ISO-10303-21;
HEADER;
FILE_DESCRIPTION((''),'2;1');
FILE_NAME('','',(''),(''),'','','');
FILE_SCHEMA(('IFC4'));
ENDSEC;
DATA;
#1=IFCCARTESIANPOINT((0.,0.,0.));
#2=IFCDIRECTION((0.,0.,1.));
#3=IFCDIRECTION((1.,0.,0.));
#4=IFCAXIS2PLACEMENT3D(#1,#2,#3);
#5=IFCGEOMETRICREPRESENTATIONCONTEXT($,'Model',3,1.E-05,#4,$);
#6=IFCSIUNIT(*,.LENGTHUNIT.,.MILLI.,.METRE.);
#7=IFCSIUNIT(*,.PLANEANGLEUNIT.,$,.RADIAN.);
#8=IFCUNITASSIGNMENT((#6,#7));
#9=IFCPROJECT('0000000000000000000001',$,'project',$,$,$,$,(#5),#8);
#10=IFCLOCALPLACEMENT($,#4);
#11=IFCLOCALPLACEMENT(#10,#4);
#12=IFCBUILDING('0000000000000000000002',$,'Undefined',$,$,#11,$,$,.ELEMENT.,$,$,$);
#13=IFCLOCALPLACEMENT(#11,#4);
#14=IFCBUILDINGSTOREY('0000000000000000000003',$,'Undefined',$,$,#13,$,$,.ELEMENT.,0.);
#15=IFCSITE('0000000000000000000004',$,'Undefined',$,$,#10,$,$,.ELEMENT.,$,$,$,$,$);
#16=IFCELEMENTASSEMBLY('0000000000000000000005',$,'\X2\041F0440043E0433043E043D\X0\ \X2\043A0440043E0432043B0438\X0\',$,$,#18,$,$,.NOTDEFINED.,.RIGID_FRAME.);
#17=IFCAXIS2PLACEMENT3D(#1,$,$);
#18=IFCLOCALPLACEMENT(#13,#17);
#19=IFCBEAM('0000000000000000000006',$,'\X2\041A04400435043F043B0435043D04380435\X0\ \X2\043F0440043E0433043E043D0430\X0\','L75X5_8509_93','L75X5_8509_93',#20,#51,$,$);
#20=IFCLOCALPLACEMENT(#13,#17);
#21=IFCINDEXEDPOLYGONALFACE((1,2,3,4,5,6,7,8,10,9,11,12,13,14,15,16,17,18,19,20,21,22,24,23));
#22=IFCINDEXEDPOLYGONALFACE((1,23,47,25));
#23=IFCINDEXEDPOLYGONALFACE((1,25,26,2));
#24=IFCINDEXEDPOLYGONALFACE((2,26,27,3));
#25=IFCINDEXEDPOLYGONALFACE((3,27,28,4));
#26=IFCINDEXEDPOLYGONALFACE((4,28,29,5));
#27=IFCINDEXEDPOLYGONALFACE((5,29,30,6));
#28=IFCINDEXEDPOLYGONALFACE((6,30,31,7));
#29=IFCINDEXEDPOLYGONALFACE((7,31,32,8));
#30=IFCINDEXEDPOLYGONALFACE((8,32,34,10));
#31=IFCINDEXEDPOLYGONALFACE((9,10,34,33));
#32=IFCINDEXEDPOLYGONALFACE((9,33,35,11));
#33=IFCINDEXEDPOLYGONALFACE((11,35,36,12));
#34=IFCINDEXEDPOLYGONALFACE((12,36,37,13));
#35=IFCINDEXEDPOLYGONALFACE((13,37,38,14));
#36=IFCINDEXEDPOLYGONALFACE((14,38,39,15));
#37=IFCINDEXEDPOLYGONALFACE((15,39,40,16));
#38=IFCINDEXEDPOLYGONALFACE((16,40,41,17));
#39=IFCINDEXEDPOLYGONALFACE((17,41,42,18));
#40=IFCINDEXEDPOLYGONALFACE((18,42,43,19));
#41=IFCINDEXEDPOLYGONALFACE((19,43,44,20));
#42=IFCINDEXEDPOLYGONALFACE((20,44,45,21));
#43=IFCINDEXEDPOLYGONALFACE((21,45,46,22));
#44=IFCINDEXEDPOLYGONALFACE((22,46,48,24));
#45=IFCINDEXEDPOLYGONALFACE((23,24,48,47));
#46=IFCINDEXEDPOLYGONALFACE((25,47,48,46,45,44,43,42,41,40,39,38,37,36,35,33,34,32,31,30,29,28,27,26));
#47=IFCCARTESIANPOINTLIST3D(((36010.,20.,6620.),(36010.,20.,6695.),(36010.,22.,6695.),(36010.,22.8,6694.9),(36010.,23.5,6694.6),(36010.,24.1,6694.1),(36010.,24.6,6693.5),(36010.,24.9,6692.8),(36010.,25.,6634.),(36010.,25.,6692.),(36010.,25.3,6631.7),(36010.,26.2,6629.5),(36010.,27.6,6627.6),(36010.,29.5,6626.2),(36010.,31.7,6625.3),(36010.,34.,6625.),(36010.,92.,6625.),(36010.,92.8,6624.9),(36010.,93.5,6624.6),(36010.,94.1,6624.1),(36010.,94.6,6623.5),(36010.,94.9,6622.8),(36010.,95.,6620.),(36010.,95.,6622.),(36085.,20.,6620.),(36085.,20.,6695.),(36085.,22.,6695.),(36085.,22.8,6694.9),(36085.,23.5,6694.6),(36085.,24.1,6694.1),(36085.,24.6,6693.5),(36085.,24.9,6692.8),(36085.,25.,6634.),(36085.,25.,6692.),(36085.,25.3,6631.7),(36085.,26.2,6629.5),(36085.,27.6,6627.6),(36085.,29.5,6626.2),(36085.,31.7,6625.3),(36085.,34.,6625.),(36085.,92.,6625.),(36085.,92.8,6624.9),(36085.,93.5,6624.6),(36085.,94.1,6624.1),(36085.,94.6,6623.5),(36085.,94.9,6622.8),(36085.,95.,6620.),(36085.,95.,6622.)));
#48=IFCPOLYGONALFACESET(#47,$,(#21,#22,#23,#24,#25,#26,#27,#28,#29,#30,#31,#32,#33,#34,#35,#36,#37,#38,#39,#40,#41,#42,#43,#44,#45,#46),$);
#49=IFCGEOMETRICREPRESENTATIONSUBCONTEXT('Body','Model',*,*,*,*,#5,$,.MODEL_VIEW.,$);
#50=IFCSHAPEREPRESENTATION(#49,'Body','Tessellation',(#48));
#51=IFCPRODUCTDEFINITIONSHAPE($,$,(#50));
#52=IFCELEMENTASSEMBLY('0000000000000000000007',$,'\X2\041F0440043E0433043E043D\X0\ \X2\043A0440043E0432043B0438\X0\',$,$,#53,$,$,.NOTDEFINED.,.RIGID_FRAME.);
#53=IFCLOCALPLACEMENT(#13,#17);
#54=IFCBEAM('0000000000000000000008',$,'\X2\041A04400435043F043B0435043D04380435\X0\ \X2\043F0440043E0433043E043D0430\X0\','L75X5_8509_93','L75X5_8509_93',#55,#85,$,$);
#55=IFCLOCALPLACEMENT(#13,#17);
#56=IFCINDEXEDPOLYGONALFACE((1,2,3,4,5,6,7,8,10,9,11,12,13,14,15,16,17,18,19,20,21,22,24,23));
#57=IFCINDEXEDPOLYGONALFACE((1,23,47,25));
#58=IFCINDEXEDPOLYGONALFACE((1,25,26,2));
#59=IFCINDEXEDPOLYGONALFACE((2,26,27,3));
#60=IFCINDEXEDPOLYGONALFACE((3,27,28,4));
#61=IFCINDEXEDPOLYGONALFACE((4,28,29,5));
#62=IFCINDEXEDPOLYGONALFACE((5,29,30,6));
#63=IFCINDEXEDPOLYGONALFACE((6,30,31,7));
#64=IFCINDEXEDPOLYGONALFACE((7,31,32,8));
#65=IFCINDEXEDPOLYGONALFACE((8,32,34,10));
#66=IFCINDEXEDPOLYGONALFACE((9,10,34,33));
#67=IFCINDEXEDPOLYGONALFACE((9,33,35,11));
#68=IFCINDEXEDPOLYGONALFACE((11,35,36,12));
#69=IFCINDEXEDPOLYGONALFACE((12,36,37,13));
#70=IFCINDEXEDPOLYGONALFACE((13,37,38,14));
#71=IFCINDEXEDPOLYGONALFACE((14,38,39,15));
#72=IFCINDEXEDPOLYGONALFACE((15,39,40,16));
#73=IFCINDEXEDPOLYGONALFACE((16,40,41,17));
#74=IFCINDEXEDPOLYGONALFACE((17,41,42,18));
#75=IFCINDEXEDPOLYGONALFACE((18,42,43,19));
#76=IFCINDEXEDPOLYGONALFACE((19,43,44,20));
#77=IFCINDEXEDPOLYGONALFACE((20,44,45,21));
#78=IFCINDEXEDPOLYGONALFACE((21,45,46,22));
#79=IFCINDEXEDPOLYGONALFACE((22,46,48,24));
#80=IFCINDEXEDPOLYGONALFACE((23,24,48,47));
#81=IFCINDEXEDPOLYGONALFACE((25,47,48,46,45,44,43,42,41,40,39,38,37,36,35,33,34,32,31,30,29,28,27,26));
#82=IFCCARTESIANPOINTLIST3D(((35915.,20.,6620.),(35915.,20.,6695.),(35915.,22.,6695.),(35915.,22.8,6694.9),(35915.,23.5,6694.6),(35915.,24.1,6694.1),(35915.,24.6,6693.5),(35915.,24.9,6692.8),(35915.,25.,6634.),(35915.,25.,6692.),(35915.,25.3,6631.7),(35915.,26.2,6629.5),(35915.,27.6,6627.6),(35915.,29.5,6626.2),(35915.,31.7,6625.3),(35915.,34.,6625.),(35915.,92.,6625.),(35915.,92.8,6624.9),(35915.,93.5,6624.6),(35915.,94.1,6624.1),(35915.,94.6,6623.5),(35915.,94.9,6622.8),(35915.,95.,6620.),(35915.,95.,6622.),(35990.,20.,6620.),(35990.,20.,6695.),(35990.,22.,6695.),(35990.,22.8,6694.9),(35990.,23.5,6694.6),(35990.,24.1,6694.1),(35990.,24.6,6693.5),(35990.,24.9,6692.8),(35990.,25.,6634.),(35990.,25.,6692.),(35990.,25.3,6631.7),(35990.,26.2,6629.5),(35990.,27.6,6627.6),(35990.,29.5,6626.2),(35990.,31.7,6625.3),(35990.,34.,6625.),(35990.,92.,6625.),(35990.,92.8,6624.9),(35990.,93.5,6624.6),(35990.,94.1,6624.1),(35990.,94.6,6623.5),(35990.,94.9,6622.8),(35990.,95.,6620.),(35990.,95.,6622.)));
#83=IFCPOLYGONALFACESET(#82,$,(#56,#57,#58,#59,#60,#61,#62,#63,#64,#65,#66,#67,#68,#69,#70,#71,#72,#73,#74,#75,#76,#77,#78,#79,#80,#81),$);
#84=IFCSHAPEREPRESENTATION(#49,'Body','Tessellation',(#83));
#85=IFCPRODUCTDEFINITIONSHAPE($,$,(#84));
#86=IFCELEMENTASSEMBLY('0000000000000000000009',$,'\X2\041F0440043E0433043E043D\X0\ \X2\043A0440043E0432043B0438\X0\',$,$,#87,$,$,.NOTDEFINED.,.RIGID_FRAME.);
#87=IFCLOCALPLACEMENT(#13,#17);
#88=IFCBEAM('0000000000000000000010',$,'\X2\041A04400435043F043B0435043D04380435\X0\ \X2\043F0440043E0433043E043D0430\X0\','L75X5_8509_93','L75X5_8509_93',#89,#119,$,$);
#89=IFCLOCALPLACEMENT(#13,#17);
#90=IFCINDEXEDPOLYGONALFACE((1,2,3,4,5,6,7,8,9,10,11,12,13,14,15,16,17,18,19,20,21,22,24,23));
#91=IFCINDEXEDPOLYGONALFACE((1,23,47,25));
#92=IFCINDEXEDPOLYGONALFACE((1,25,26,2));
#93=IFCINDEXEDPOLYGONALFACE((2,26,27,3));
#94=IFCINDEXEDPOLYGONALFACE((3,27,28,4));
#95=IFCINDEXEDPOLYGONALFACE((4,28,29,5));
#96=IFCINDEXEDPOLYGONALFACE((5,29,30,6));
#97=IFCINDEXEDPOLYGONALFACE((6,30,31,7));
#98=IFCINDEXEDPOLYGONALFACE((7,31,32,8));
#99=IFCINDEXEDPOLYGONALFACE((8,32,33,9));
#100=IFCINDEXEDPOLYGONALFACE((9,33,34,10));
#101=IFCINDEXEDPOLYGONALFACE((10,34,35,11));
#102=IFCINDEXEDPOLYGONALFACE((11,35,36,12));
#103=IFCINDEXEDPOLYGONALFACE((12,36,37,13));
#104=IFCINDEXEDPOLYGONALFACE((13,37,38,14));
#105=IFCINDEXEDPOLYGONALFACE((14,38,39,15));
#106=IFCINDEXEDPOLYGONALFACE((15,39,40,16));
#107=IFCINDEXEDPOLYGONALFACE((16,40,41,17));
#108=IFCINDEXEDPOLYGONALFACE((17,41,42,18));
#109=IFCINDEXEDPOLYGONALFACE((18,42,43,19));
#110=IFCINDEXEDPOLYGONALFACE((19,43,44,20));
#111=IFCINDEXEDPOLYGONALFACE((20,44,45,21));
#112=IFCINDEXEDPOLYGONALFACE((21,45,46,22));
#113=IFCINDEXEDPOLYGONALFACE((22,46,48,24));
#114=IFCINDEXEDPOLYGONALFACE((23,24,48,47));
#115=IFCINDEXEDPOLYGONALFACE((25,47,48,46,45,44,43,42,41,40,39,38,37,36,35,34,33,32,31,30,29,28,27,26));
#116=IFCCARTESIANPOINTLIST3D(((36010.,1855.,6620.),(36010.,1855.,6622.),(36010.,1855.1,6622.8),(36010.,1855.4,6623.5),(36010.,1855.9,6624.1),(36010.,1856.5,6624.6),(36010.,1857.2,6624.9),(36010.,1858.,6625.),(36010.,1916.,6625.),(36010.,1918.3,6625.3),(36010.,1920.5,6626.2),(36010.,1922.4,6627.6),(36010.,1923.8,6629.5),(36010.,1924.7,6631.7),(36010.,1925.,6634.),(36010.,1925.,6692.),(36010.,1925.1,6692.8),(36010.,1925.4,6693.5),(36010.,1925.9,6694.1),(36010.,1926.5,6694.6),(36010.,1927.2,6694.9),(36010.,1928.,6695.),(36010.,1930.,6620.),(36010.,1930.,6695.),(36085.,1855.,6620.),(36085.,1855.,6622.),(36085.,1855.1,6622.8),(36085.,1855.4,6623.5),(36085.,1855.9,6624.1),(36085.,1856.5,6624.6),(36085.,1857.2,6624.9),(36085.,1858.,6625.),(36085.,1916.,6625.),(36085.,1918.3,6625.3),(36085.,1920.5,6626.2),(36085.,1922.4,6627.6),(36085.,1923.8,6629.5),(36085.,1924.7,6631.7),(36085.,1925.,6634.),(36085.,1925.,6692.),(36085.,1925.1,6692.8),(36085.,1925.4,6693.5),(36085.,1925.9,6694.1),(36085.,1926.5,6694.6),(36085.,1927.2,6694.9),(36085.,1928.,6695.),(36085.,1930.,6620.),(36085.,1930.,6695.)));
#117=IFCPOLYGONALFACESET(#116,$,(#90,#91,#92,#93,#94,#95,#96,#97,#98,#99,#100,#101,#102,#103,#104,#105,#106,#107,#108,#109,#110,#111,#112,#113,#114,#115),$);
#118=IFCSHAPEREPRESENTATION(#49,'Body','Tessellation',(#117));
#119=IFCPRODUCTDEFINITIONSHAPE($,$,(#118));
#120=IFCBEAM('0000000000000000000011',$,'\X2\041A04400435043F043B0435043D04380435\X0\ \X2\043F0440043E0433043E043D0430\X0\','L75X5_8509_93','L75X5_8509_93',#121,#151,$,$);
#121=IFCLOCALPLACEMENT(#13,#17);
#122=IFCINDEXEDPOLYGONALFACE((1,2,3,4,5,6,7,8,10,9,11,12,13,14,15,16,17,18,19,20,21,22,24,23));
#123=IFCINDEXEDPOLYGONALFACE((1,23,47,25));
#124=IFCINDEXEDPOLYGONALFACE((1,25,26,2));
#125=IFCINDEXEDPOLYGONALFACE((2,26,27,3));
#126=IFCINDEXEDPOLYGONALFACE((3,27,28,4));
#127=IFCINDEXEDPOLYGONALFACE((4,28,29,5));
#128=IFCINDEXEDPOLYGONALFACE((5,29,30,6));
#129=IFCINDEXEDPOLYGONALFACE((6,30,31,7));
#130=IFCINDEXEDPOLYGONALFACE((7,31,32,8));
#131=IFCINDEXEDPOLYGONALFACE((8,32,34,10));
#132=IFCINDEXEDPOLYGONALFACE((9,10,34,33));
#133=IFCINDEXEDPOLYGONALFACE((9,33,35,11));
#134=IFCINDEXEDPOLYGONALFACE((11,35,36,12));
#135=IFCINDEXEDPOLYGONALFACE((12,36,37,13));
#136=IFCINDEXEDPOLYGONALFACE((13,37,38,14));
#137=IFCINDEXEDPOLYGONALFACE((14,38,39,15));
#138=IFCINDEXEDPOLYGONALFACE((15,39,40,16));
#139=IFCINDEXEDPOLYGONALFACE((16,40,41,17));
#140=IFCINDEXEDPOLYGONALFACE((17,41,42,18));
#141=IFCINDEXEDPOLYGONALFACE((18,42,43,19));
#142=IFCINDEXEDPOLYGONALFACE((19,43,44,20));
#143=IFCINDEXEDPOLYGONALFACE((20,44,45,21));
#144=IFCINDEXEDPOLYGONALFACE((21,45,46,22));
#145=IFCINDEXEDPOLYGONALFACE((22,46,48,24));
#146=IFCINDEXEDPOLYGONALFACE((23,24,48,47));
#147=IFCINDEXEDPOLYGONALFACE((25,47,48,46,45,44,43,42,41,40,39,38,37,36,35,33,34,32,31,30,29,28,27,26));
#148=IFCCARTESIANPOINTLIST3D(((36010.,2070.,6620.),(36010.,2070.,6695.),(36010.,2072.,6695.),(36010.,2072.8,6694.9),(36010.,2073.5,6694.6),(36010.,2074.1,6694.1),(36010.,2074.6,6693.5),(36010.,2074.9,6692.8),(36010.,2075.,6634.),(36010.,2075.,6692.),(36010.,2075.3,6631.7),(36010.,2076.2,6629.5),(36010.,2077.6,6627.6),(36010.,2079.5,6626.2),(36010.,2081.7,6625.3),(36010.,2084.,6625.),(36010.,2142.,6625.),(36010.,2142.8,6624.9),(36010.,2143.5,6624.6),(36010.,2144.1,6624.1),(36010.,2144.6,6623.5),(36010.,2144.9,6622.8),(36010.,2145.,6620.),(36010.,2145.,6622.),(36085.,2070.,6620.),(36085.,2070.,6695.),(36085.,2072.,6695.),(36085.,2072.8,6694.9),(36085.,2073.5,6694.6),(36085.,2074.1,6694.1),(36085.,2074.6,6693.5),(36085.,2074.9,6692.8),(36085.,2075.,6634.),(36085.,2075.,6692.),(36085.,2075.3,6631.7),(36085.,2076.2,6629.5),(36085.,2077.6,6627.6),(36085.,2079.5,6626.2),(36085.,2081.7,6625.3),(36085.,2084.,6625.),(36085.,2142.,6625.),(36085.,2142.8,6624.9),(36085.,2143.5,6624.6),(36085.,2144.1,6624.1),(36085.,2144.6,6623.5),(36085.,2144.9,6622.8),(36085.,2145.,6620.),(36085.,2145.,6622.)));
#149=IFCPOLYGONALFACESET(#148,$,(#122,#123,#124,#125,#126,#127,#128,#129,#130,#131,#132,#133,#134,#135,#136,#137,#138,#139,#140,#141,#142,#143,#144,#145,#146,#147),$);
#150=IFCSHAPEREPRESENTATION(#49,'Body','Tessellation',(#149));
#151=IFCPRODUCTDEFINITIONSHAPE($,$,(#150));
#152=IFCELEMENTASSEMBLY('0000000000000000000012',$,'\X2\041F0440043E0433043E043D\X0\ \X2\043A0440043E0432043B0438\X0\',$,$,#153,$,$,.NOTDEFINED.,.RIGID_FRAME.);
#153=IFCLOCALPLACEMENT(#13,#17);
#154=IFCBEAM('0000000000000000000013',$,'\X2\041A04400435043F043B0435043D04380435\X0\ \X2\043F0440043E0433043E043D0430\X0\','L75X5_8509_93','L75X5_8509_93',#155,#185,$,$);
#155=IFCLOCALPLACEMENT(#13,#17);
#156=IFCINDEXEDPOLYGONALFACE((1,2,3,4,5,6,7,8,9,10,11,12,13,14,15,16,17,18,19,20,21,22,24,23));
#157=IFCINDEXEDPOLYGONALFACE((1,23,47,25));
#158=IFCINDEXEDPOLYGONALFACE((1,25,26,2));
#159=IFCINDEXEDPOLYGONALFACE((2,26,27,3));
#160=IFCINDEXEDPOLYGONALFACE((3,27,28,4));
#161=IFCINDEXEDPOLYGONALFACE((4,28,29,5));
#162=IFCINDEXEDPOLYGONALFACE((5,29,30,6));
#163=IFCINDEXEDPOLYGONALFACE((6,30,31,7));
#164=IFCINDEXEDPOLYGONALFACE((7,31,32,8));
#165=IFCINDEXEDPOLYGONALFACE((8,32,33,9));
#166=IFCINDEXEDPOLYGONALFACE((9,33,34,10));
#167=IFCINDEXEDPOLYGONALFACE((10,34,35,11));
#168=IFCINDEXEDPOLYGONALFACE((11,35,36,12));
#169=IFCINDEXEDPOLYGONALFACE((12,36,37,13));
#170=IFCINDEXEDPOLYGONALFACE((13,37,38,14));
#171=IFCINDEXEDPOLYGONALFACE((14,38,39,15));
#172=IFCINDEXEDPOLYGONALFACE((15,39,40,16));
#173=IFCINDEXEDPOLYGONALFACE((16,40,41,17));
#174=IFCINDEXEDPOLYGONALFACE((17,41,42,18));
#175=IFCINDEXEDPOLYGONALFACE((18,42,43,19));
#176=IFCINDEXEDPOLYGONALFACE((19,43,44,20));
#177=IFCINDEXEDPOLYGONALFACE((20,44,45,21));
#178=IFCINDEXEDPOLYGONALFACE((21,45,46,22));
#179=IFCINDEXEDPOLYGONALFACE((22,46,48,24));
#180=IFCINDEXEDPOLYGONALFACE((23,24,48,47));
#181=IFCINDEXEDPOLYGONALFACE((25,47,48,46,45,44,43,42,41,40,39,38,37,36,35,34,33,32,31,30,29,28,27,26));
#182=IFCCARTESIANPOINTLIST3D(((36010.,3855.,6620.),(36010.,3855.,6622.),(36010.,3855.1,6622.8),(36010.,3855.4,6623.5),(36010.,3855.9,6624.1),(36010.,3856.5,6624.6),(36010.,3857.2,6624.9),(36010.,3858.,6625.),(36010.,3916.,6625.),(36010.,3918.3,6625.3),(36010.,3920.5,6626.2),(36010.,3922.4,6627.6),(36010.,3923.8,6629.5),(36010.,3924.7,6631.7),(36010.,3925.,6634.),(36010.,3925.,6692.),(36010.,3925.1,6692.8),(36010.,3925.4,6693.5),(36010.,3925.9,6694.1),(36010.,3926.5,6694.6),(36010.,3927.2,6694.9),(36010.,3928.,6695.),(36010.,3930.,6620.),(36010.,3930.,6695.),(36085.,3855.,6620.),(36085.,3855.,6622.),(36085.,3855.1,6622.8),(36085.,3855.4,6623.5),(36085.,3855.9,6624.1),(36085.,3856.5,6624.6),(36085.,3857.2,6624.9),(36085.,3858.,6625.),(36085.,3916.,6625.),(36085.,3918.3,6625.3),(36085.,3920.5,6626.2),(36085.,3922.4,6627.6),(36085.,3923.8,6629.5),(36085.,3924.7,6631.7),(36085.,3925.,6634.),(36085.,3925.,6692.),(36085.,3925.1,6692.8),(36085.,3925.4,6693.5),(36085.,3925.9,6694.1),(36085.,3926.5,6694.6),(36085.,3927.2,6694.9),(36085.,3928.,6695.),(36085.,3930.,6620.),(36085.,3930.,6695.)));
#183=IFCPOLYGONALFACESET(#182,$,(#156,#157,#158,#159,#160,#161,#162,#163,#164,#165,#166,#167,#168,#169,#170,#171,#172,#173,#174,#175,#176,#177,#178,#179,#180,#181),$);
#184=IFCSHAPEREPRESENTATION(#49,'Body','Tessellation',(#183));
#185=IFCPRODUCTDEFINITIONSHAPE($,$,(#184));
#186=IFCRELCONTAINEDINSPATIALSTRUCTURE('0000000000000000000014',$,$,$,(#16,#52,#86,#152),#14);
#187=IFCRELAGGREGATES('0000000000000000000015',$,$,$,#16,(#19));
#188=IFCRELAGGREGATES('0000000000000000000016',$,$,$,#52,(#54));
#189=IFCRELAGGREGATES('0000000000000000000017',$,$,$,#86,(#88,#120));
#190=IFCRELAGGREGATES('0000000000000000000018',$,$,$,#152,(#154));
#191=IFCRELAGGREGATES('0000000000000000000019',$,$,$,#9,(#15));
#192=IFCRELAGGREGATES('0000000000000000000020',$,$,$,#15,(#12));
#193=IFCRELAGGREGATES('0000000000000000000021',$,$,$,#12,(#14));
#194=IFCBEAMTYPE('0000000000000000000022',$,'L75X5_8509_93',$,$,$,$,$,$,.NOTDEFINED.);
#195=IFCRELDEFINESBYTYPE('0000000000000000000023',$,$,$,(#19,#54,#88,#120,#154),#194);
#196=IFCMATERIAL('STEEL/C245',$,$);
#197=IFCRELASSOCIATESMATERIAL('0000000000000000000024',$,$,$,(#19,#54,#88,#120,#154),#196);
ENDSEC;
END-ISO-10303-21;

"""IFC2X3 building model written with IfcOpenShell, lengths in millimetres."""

from ifc_helpers import new_model, si_unit, frame, origin_with_axes, origin_2d_with_axis, place, context, subcontext, project, spatial, l_section, extrude, material, type_object, element, aggregate, save


model = new_model("IFC2X3")

# Units and contexts
model_context = context("Model", 3, precision=1e-05, world=origin_with_axes())
body_context = subcontext(model_context, "Body", "Model", "MODEL_VIEW")
ifc_project = project(units=[si_unit("LENGTHUNIT", "METRE", prefix="MILLI"), si_unit("PLANEANGLEUNIT", "RADIAN")], contexts=[model_context])

# Site, building, storey
site_placement = place(None, origin_with_axes())
site = spatial("IfcSite", under=ifc_project, at=site_placement, Name="Undefined", CompositionType="ELEMENT")
building_placement = place(site_placement, origin_with_axes())
building = spatial("IfcBuilding", under=site, at=building_placement, Name="Undefined", CompositionType="ELEMENT")
storey_placement = place(building_placement, origin_with_axes())
storey = spatial("IfcBuildingStorey", under=building, at=storey_placement, Name="Undefined", CompositionType="ELEMENT", Elevation=0.0)

# Element assemblies, beams
assembly_1_placement = place(storey_placement, origin_with_axes())
assembly_1 = element("IfcElementAssembly", 1, at=assembly_1_placement, inside=storey, Name="Прогон кровли", AssemblyPlace="NOTDEFINED", PredefinedType="RIGID_FRAME")
ifc_material_1 = material(Name="STEEL/C245")
beam_type_1 = type_object("IfcBeamType", Name="L75X5_8509_93", PredefinedType="NOTDEFINED")
beam_1_placement = place(assembly_1_placement, frame((36010.0, 57.5, 6657.5), z_axis=(0.0, 1.0, 0.0), x_axis=(1.0, 0.0, 0.0)))
beam_1 = element("IfcBeam", 2, at=beam_1_placement, type_object=beam_type_1, material=ifc_material_1, Name="Крепление прогона", Description="L75X5_8509_93", ObjectType="L75X5_8509_93", context=body_context, shape_type="SweptSolid", body=[
    extrude(l_section(Depth=75.0, Width=75.0, Thickness=5.0, FilletRadius=9.0, EdgeRadius=3.0, at=origin_2d_with_axis()), frame((75.0, 0.0, 0.0), z_axis=(-1.0, 0.0, 0.0), x_axis=(0.0, -1.0, 0.0)), (0.0, 0.0, 1.0), 75.0),
])
assembly_2_placement = place(storey_placement, origin_with_axes())
assembly_2 = element("IfcElementAssembly", 3, at=assembly_2_placement, inside=storey, Name="Прогон кровли", AssemblyPlace="NOTDEFINED", PredefinedType="RIGID_FRAME")
beam_2_placement = place(assembly_2_placement, frame((35915.0, 57.5, 6657.5), z_axis=(0.0, 1.0, 0.0), x_axis=(1.0, 0.0, 0.0)))
beam_2 = element("IfcBeam", 4, at=beam_2_placement, type_object=beam_type_1, material=ifc_material_1, Name="Крепление прогона", Description="L75X5_8509_93", ObjectType="L75X5_8509_93", context=body_context, shape_type="SweptSolid", body=[
    extrude(l_section(Depth=75.0, Width=75.0, Thickness=5.0, FilletRadius=9.0, EdgeRadius=3.0, at=origin_2d_with_axis()), frame((75.0, 0.0, 0.0), z_axis=(-1.0, 0.0, 0.0), x_axis=(0.0, -1.0, 0.0)), (0.0, 0.0, 1.0), 75.0),
])

# Element assemblies, beams
assembly_3_placement = place(storey_placement, origin_with_axes())
assembly_3 = element("IfcElementAssembly", 5, at=assembly_3_placement, inside=storey, Name="Прогон кровли", AssemblyPlace="NOTDEFINED", PredefinedType="RIGID_FRAME")
beam_3_placement = place(assembly_3_placement, frame((36085.0, 1892.5, 6657.5), z_axis=(0.0, -1.0, 0.0), x_axis=(-1.0, 0.0, 0.0)))
beam_3 = element("IfcBeam", 6, at=beam_3_placement, type_object=beam_type_1, material=ifc_material_1, Name="Крепление прогона", Description="L75X5_8509_93", ObjectType="L75X5_8509_93", context=body_context, shape_type="SweptSolid", body=[
    extrude(l_section(Depth=75.0, Width=75.0, Thickness=5.0, FilletRadius=9.0, EdgeRadius=3.0, at=origin_2d_with_axis()), frame((75.0, 0.0, 0.0), z_axis=(-1.0, 0.0, 0.0), x_axis=(0.0, -1.0, 0.0)), (0.0, 0.0, 1.0), 75.0),
])
beam_4_placement = place(assembly_3_placement, frame((36010.0, 2107.5, 6657.5), z_axis=(0.0, 1.0, 0.0), x_axis=(1.0, 0.0, 0.0)))
beam_4 = element("IfcBeam", 7, at=beam_4_placement, type_object=beam_type_1, material=ifc_material_1, Name="Крепление прогона", Description="L75X5_8509_93", ObjectType="L75X5_8509_93", context=body_context, shape_type="SweptSolid", body=[
    extrude(l_section(Depth=75.0, Width=75.0, Thickness=5.0, FilletRadius=9.0, EdgeRadius=3.0, at=origin_2d_with_axis()), frame((75.0, 0.0, 0.0), z_axis=(-1.0, 0.0, 0.0), x_axis=(0.0, -1.0, 0.0)), (0.0, 0.0, 1.0), 75.0),
])
assembly_4_placement = place(storey_placement, origin_with_axes())
assembly_4 = element("IfcElementAssembly", 8, at=assembly_4_placement, inside=storey, Name="Прогон кровли", AssemblyPlace="NOTDEFINED", PredefinedType="RIGID_FRAME")
beam_5_placement = place(assembly_4_placement, frame((36085.0, 3892.5, 6657.5), z_axis=(0.0, -1.0, 0.0), x_axis=(-1.0, 0.0, 0.0)))
beam_5 = element("IfcBeam", 9, at=beam_5_placement, type_object=beam_type_1, material=ifc_material_1, Name="Крепление прогона", Description="L75X5_8509_93", ObjectType="L75X5_8509_93", context=body_context, shape_type="SweptSolid", body=[
    extrude(l_section(Depth=75.0, Width=75.0, Thickness=5.0, FilletRadius=9.0, EdgeRadius=3.0, at=origin_2d_with_axis()), frame((75.0, 0.0, 0.0), z_axis=(-1.0, 0.0, 0.0), x_axis=(0.0, -1.0, 0.0)), (0.0, 0.0, 1.0), 75.0),
])

aggregate(assembly_1, [beam_1])
aggregate(assembly_2, [beam_2])
aggregate(assembly_3, [beam_3, beam_4])

aggregate(assembly_4, [beam_5])

save(model, "model.ifc")
